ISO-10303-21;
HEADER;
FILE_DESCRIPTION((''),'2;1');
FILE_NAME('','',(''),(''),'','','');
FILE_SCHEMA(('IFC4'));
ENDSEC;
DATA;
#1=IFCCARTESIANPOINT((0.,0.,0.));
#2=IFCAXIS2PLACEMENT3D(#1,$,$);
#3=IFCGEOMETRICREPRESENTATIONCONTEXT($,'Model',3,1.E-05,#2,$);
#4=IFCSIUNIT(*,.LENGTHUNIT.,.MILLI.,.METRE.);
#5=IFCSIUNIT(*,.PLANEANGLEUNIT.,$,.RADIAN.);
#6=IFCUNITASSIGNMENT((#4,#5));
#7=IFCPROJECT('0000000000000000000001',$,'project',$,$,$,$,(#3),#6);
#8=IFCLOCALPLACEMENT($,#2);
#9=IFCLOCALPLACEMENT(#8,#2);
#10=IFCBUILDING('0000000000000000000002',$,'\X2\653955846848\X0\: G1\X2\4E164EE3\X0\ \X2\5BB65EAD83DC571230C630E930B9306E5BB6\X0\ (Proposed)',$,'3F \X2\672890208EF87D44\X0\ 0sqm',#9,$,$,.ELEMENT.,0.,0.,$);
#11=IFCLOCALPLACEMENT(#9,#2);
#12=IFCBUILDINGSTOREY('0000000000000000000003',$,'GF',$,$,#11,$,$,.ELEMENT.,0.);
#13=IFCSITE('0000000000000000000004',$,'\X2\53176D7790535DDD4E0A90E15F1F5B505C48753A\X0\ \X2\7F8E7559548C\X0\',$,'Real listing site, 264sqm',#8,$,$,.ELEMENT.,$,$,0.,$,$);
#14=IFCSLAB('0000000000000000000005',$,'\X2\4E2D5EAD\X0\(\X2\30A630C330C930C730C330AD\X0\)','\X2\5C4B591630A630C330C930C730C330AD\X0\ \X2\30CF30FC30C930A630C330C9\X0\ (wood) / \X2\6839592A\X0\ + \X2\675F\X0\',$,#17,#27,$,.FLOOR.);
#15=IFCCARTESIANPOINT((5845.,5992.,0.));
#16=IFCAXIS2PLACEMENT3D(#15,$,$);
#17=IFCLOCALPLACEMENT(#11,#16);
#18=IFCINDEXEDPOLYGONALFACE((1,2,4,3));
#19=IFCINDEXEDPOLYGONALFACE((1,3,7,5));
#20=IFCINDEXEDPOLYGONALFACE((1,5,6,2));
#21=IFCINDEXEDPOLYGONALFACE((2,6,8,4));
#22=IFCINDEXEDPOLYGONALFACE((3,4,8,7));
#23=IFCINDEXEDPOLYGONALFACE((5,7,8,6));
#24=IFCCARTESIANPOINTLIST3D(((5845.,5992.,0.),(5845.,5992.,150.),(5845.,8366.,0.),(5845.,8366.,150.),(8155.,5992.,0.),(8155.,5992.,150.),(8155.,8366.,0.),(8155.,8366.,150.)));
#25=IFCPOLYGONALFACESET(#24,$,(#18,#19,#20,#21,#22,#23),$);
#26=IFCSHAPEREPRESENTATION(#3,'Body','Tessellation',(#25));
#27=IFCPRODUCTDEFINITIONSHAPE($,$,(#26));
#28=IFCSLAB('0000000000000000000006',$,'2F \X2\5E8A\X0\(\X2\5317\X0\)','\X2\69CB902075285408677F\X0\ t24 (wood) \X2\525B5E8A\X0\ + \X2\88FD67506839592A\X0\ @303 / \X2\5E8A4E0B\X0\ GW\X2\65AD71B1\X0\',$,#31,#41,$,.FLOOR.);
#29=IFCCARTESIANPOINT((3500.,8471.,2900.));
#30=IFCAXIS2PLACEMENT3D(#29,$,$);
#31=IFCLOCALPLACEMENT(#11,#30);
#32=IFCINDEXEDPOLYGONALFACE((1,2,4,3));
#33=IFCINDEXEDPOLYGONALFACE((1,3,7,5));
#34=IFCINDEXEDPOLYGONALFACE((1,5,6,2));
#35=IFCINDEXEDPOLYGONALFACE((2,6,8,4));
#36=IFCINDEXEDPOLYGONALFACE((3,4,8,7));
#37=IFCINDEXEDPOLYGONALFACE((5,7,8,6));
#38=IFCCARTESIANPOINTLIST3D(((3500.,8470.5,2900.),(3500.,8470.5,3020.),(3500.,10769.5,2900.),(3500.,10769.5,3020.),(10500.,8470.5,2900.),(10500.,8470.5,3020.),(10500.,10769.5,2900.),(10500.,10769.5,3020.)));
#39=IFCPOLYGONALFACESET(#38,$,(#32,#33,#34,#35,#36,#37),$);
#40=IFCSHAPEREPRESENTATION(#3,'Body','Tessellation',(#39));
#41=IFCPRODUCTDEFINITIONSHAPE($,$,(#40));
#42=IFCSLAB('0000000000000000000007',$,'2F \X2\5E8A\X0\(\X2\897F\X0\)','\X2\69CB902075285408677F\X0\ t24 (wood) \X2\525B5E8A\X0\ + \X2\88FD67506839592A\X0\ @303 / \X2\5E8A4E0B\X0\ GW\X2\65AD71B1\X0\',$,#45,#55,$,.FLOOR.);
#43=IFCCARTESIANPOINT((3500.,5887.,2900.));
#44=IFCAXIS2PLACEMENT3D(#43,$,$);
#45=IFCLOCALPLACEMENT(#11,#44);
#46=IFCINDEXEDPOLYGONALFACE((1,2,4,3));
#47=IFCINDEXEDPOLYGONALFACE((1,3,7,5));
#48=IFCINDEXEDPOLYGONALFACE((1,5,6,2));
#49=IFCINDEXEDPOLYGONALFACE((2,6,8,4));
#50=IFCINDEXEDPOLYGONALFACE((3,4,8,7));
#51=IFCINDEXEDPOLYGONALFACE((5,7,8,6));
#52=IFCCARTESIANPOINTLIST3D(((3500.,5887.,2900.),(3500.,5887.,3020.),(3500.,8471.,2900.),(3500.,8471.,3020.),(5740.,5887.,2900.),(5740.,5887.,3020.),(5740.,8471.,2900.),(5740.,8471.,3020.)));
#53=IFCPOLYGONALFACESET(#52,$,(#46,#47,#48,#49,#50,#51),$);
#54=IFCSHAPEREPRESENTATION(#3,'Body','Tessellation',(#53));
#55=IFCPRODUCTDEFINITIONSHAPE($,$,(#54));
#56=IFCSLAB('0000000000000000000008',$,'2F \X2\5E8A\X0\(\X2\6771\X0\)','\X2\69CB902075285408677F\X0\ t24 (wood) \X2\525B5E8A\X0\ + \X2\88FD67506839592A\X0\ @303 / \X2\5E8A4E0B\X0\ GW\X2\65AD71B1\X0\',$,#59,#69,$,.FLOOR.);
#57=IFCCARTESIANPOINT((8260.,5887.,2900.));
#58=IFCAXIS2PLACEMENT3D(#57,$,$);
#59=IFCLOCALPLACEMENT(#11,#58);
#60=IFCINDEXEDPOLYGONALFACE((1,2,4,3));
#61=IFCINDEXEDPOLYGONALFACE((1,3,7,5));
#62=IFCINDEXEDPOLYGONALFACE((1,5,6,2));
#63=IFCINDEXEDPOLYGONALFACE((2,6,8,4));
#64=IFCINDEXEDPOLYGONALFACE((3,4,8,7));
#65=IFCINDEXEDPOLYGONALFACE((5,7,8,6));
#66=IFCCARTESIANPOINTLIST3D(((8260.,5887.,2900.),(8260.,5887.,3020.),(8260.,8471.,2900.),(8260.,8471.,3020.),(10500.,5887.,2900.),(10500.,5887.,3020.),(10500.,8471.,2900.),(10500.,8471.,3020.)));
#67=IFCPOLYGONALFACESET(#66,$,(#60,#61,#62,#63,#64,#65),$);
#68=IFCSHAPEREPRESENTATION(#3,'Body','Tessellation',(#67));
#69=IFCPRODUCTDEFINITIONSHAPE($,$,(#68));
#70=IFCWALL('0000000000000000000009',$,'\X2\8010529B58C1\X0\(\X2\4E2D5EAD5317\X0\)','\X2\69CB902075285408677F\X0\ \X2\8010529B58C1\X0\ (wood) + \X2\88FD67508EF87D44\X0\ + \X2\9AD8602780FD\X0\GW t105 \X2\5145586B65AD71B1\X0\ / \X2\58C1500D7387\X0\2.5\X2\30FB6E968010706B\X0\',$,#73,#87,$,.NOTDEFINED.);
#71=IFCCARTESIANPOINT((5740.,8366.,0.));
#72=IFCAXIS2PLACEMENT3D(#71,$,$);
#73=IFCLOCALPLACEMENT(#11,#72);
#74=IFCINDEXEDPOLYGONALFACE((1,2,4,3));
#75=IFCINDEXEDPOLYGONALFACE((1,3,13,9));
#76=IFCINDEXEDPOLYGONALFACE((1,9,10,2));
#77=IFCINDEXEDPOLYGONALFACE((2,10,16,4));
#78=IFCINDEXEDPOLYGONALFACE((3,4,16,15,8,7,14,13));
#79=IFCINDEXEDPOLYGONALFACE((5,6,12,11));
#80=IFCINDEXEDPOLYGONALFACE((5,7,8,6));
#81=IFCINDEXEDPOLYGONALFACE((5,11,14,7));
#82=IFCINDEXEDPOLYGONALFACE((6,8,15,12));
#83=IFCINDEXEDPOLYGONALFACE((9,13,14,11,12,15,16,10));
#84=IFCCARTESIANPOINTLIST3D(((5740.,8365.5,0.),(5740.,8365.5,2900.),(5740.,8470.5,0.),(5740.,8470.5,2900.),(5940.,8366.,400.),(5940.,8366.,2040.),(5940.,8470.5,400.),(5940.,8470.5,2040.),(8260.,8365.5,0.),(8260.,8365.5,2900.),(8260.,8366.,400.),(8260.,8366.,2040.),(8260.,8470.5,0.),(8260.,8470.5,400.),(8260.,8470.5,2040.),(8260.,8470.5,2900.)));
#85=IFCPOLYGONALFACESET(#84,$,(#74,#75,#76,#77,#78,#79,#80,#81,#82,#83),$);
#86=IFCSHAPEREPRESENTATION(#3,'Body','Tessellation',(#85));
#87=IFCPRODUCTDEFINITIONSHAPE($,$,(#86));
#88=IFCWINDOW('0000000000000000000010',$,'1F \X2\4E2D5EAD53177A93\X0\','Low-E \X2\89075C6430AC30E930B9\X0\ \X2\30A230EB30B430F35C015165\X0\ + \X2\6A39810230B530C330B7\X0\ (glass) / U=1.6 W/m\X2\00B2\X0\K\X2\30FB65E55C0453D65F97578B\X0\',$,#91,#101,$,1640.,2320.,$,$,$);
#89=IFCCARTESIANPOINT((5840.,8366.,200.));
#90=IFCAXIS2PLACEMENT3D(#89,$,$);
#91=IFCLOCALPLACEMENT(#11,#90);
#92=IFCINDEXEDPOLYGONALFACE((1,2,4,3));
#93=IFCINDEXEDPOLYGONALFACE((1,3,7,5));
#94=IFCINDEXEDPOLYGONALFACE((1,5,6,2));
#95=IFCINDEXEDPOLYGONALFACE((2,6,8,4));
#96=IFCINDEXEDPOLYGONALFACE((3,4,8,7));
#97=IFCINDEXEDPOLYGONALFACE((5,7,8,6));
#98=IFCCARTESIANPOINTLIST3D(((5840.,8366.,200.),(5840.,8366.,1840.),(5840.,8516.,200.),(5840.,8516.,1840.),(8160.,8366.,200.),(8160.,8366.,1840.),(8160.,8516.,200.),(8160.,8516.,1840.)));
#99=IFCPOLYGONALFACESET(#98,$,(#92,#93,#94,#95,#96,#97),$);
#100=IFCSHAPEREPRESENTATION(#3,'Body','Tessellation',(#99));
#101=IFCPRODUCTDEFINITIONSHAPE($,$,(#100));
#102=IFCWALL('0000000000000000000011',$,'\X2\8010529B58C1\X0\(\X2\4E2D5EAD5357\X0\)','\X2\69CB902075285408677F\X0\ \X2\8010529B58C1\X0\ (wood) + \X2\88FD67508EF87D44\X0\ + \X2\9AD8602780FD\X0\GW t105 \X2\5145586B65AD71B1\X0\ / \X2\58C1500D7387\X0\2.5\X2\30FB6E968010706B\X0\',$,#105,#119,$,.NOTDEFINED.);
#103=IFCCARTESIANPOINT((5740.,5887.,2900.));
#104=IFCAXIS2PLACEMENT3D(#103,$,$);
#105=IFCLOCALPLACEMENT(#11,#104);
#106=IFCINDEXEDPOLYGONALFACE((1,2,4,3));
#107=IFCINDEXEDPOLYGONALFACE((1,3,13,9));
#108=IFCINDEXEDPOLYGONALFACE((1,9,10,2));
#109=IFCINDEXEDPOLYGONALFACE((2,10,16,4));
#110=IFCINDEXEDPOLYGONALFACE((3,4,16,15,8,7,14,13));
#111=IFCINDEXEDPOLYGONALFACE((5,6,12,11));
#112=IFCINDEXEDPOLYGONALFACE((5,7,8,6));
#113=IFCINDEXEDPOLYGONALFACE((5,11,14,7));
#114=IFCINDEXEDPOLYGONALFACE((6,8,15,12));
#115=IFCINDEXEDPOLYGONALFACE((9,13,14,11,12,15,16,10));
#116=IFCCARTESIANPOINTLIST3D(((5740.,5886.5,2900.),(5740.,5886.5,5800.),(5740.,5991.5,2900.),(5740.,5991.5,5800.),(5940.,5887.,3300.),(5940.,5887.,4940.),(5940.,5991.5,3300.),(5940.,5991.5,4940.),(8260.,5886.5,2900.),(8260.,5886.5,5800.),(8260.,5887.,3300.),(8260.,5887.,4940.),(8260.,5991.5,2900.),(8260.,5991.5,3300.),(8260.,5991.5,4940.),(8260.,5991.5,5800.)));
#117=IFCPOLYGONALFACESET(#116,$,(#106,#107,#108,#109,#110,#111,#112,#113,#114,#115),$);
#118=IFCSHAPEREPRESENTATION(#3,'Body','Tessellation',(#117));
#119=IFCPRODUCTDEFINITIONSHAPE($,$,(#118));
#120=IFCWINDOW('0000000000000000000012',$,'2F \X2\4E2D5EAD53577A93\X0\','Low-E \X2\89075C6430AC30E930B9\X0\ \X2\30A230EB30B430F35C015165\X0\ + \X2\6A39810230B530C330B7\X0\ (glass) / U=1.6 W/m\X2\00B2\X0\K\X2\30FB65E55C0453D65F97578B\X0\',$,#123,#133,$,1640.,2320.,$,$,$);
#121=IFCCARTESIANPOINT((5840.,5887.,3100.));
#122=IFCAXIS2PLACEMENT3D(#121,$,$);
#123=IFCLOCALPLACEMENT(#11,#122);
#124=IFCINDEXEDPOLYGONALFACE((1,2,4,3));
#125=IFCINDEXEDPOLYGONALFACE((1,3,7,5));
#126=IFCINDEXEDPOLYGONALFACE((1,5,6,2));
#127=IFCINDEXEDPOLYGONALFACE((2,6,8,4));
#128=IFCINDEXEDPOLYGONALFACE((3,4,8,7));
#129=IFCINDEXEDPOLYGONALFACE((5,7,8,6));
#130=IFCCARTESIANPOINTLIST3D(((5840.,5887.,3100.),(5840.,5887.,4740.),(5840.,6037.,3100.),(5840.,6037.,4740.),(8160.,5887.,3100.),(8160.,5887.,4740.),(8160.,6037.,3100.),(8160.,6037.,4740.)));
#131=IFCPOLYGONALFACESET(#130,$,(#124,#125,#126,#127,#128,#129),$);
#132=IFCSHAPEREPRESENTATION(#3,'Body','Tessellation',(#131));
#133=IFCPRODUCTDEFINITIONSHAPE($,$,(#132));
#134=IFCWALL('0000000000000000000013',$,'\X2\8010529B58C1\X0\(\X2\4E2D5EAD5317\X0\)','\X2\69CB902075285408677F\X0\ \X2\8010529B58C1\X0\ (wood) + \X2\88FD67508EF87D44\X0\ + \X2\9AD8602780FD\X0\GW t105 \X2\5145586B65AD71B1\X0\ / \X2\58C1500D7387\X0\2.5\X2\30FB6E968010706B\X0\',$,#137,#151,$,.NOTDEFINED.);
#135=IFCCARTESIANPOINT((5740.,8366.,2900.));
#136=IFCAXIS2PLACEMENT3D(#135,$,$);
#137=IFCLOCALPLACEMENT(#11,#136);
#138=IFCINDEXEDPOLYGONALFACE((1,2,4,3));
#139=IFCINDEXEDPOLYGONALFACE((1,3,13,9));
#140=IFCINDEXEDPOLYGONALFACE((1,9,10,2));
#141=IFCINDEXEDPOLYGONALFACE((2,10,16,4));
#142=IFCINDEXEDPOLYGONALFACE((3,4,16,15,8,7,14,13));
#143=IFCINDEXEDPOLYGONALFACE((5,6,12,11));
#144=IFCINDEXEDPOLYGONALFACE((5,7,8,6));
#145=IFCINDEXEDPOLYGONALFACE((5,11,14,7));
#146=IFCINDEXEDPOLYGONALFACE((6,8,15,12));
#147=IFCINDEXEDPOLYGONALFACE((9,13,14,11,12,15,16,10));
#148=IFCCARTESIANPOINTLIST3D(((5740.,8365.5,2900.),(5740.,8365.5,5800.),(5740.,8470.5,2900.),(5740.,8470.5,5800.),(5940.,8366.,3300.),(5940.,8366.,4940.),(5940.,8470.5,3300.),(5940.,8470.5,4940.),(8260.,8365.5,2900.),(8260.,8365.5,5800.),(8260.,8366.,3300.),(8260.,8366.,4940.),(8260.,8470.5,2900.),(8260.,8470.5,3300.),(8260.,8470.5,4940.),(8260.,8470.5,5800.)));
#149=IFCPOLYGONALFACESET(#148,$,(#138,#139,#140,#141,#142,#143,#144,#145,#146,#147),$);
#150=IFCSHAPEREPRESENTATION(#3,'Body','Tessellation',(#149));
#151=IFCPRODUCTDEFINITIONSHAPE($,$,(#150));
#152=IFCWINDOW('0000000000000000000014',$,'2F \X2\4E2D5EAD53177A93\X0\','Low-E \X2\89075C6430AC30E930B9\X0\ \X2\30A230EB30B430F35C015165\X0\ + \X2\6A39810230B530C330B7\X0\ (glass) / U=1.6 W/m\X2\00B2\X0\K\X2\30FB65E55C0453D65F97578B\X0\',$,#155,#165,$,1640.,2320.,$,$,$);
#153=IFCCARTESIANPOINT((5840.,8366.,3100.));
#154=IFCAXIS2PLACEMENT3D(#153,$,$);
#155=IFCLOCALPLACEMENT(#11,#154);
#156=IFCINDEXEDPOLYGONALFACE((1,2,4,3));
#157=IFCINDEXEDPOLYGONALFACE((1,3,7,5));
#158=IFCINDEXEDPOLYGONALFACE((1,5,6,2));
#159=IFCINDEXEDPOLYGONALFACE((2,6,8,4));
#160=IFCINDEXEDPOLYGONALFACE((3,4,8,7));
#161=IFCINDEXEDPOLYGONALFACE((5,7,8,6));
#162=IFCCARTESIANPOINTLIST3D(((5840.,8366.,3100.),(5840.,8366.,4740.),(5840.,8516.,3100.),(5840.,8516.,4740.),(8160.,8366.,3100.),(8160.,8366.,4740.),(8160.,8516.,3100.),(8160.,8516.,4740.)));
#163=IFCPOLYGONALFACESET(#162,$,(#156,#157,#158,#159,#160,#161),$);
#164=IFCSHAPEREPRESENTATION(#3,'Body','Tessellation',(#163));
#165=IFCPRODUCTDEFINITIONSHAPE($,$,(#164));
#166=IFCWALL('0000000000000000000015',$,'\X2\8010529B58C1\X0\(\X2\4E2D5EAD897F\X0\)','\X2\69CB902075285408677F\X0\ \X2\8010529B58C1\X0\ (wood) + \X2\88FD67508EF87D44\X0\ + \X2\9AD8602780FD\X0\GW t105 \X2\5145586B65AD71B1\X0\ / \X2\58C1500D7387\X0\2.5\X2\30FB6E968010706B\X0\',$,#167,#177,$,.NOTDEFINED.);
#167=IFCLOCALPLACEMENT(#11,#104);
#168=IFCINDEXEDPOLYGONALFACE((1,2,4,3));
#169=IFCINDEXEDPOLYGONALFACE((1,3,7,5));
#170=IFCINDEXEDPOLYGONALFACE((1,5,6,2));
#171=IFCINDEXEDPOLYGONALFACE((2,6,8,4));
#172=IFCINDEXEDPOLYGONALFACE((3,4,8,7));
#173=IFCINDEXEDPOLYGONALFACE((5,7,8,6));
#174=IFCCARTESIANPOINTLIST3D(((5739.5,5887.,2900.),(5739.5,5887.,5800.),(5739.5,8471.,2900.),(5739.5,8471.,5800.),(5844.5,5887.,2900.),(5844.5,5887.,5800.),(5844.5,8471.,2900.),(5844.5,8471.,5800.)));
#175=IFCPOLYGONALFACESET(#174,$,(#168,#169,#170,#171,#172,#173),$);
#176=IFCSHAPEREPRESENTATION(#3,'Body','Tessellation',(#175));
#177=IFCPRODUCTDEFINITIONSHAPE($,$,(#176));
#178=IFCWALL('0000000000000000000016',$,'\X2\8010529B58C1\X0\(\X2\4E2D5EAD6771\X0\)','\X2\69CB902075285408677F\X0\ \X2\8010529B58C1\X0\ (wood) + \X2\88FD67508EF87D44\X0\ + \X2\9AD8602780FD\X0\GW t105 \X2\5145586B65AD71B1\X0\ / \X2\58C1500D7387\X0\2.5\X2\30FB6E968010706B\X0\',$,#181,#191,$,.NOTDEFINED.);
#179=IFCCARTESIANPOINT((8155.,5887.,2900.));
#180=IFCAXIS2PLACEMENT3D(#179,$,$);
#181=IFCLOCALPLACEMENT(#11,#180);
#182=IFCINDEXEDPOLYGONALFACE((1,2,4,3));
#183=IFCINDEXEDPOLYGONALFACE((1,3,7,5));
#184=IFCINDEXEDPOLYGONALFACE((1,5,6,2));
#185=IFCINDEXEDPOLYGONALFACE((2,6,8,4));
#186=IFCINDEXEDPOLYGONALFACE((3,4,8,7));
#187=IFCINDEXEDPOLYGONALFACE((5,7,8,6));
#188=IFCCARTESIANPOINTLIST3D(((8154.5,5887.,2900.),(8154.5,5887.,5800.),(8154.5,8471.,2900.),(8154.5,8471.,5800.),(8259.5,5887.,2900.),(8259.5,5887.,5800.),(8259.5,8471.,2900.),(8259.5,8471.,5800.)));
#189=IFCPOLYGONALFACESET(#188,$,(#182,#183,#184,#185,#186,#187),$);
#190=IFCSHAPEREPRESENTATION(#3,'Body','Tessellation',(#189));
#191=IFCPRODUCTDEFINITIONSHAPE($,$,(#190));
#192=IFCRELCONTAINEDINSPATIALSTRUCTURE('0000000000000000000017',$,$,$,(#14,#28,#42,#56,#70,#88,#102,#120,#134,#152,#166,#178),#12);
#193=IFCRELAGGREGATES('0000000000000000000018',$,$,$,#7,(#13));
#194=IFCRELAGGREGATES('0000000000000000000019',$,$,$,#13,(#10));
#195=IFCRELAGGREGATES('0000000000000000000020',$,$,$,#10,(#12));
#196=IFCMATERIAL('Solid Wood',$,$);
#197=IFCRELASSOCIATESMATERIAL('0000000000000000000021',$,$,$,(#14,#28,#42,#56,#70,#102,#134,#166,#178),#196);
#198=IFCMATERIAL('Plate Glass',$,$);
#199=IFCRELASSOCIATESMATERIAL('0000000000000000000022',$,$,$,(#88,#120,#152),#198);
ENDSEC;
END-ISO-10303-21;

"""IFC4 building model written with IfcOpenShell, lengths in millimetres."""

from ifc_helpers import new_model, si_unit, frame, frame_2d, origin, place, context, project, spatial, rectangle, extrude, material, element, fill, save


model = new_model("IFC4")

# Units and contexts
model_context = context("Model", 3, precision=1e-05, world=origin())
ifc_project = project(units=[si_unit("LENGTHUNIT", "METRE", prefix="MILLI"), si_unit("PLANEANGLEUNIT", "RADIAN")], contexts=[model_context])

# Site, building, storey
site_placement = place(None, origin())
site = spatial("IfcSite", under=ifc_project, at=site_placement, Name="北海道川上郡弟子屈町 美留和", ObjectType="Real listing site, 264sqm", CompositionType="ELEMENT", RefElevation=0.0)
building_placement = place(site_placement, origin())
building = spatial("IfcBuilding", under=site, at=building_placement, Name="改善案: G1世代 家庭菜園テラスの家 (Proposed)", ObjectType="3F 木造軸組 0sqm", CompositionType="ELEMENT", ElevationOfRefHeight=0.0, ElevationOfTerrain=0.0)
storey_placement = place(building_placement, origin())
storey = spatial("IfcBuildingStorey", under=building, at=storey_placement, Name="GF", CompositionType="ELEMENT", Elevation=0.0)

# Slabs
ifc_material_1 = material(Name="Solid Wood")
slab_1_placement = place(storey_placement, frame((5845.0, 5992.0, 0.0)))
element("IfcSlab", 1, at=slab_1_placement, inside=storey, material=ifc_material_1, Name="中庭(ウッドデッキ)", Description="屋外ウッドデッキ ハードウッド (wood) / 根太 + 束", PredefinedType="FLOOR", context=model_context, shape_type="SweptSolid", body=[
    extrude(rectangle(XDim=2310.0, YDim=2374.0, at=frame_2d((1155.0, 1187.0))), frame((5845.0, 5992.0, 0.0)), (0.0, 0.0, 1.0), 150.0),
])
slab_2_placement = place(storey_placement, frame((3500.0, 8471.0, 2900.0)))
element("IfcSlab", 2, at=slab_2_placement, inside=storey, material=ifc_material_1, Name="2F 床(北)", Description="構造用合板 t24 (wood) 剛床 + 製材根太 @303 / 床下 GW断熱", PredefinedType="FLOOR", context=model_context, shape_type="SweptSolid", body=[
    extrude(rectangle(XDim=7000.0, YDim=2299.0, at=frame_2d((3500.0, 1149.0))), frame((3500.0, 8471.0, 2900.0)), (0.0, 0.0, 1.0), 120.0),
])
slab_3_placement = place(storey_placement, frame((3500.0, 5887.0, 2900.0)))
element("IfcSlab", 3, at=slab_3_placement, inside=storey, material=ifc_material_1, Name="2F 床(西)", Description="構造用合板 t24 (wood) 剛床 + 製材根太 @303 / 床下 GW断熱", PredefinedType="FLOOR", context=model_context, shape_type="SweptSolid", body=[
    extrude(rectangle(XDim=2240.0, YDim=2584.0, at=frame_2d((1120.0, 1292.0))), frame((3500.0, 5887.0, 2900.0)), (0.0, 0.0, 1.0), 120.0),
])
slab_4_placement = place(storey_placement, frame((8260.0, 5887.0, 2900.0)))
element("IfcSlab", 4, at=slab_4_placement, inside=storey, material=ifc_material_1, Name="2F 床(東)", Description="構造用合板 t24 (wood) 剛床 + 製材根太 @303 / 床下 GW断熱", PredefinedType="FLOOR", context=model_context, shape_type="SweptSolid", body=[
    extrude(rectangle(XDim=2240.0, YDim=2584.0, at=frame_2d((1120.0, 1292.0))), frame((8260.0, 5887.0, 2900.0)), (0.0, 0.0, 1.0), 120.0),
])

# Wall, opening, window
wall_1_placement = place(storey_placement, frame((5740.0, 8366.0, 0.0)))
wall_1 = element("IfcWall", 5, at=wall_1_placement, inside=storey, material=ifc_material_1, Name="耐力壁(中庭北)", Description="構造用合板 耐力壁 (wood) + 製材軸組 + 高性能GW t105 充填断熱 / 壁倍率2.5・準耐火", PredefinedType="NOTDEFINED", context=model_context, shape_type="SweptSolid", body=[
    extrude(rectangle(XDim=2520.0, YDim=105.0, at=frame_2d((1260.0, 52.0))), frame((5740.0, 8366.0, 0.0)), (0.0, 0.0, 1.0), 2900.0),
])
opening_1_placement = place(storey_placement, frame((5840.0, 8366.0, 200.0)))
opening_1 = element("IfcOpeningElement", 6, at=opening_1_placement, cuts=wall_1, PredefinedType="NOTDEFINED", context=model_context, shape_type="SweptSolid", body=[
    extrude(rectangle(XDim=2320.0, YDim=150.0, at=frame_2d((1160.0, 75.0))), frame((5840.0, 8366.0, 200.0)), (0.0, 0.0, 1.0), 1640.0),
])
ifc_material_2 = material(Name="Plate Glass")
window_1_placement = place(storey_placement, frame((5840.0, 8366.0, 200.0)))
window_1 = element("IfcWindow", 7, at=window_1_placement, inside=storey, material=ifc_material_2, Name="1F 中庭北窓", Description="Low-E 複層ガラス アルゴン封入 + 樹脂サッシ (glass) / U=1.6 W/m²K・日射取得型", OverallHeight=1640.0, OverallWidth=2320.0, context=model_context, shape_type="SweptSolid", body=[
    extrude(rectangle(XDim=2320.0, YDim=150.0, at=frame_2d((1160.0, 75.0))), frame((5840.0, 8366.0, 200.0)), (0.0, 0.0, 1.0), 1640.0),
])
fill(opening_1, window_1)

# Walls, openings, windows
wall_2_placement = place(storey_placement, frame((5740.0, 5887.0, 2900.0)))
wall_2 = element("IfcWall", 8, at=wall_2_placement, inside=storey, material=ifc_material_1, Name="耐力壁(中庭南)", Description="構造用合板 耐力壁 (wood) + 製材軸組 + 高性能GW t105 充填断熱 / 壁倍率2.5・準耐火", PredefinedType="NOTDEFINED", context=model_context, shape_type="SweptSolid", body=[
    extrude(rectangle(XDim=2520.0, YDim=105.0, at=frame_2d((1260.0, 52.0))), frame((5740.0, 5887.0, 2900.0)), (0.0, 0.0, 1.0), 2900.0),
])
opening_2_placement = place(storey_placement, frame((5840.0, 5887.0, 3100.0)))
opening_2 = element("IfcOpeningElement", 9, at=opening_2_placement, cuts=wall_2, PredefinedType="NOTDEFINED", context=model_context, shape_type="SweptSolid", body=[
    extrude(rectangle(XDim=2320.0, YDim=150.0, at=frame_2d((1160.0, 75.0))), frame((5840.0, 5887.0, 3100.0)), (0.0, 0.0, 1.0), 1640.0),
])
window_2_placement = place(storey_placement, frame((5840.0, 5887.0, 3100.0)))
window_2 = element("IfcWindow", 10, at=window_2_placement, inside=storey, material=ifc_material_2, Name="2F 中庭南窓", Description="Low-E 複層ガラス アルゴン封入 + 樹脂サッシ (glass) / U=1.6 W/m²K・日射取得型", OverallHeight=1640.0, OverallWidth=2320.0, context=model_context, shape_type="SweptSolid", body=[
    extrude(rectangle(XDim=2320.0, YDim=150.0, at=frame_2d((1160.0, 75.0))), frame((5840.0, 5887.0, 3100.0)), (0.0, 0.0, 1.0), 1640.0),
])
fill(opening_2, window_2)
wall_3_placement = place(storey_placement, frame((5740.0, 8366.0, 2900.0)))
wall_3 = element("IfcWall", 11, at=wall_3_placement, inside=storey, material=ifc_material_1, Name="耐力壁(中庭北)", Description="構造用合板 耐力壁 (wood) + 製材軸組 + 高性能GW t105 充填断熱 / 壁倍率2.5・準耐火", PredefinedType="NOTDEFINED", context=model_context, shape_type="SweptSolid", body=[
    extrude(rectangle(XDim=2520.0, YDim=105.0, at=frame_2d((1260.0, 52.0))), frame((5740.0, 8366.0, 2900.0)), (0.0, 0.0, 1.0), 2900.0),
])
opening_3_placement = place(storey_placement, frame((5840.0, 8366.0, 3100.0)))
opening_3 = element("IfcOpeningElement", 12, at=opening_3_placement, cuts=wall_3, PredefinedType="NOTDEFINED", context=model_context, shape_type="SweptSolid", body=[
    extrude(rectangle(XDim=2320.0, YDim=150.0, at=frame_2d((1160.0, 75.0))), frame((5840.0, 8366.0, 3100.0)), (0.0, 0.0, 1.0), 1640.0),
])
window_3_placement = place(storey_placement, frame((5840.0, 8366.0, 3100.0)))
window_3 = element("IfcWindow", 13, at=window_3_placement, inside=storey, material=ifc_material_2, Name="2F 中庭北窓", Description="Low-E 複層ガラス アルゴン封入 + 樹脂サッシ (glass) / U=1.6 W/m²K・日射取得型", OverallHeight=1640.0, OverallWidth=2320.0, context=model_context, shape_type="SweptSolid", body=[
    extrude(rectangle(XDim=2320.0, YDim=150.0, at=frame_2d((1160.0, 75.0))), frame((5840.0, 8366.0, 3100.0)), (0.0, 0.0, 1.0), 1640.0),
])
fill(opening_3, window_3)

# Walls
wall_4_placement = place(storey_placement, frame((5740.0, 5887.0, 2900.0)))
element("IfcWall", 14, at=wall_4_placement, inside=storey, material=ifc_material_1, Name="耐力壁(中庭西)", Description="構造用合板 耐力壁 (wood) + 製材軸組 + 高性能GW t105 充填断熱 / 壁倍率2.5・準耐火", PredefinedType="NOTDEFINED", context=model_context, shape_type="SweptSolid", body=[
    extrude(rectangle(XDim=105.0, YDim=2584.0, at=frame_2d((52.0, 1292.0))), frame((5740.0, 5887.0, 2900.0)), (0.0, 0.0, 1.0), 2900.0),
])
wall_5_placement = place(storey_placement, frame((8155.0, 5887.0, 2900.0)))
element("IfcWall", 15, at=wall_5_placement, inside=storey, material=ifc_material_1, Name="耐力壁(中庭東)", Description="構造用合板 耐力壁 (wood) + 製材軸組 + 高性能GW t105 充填断熱 / 壁倍率2.5・準耐火", PredefinedType="NOTDEFINED", context=model_context, shape_type="SweptSolid", body=[
    extrude(rectangle(XDim=105.0, YDim=2584.0, at=frame_2d((52.0, 1292.0))), frame((8155.0, 5887.0, 2900.0)), (0.0, 0.0, 1.0), 2900.0),
])

save(model, "model.ifc")
